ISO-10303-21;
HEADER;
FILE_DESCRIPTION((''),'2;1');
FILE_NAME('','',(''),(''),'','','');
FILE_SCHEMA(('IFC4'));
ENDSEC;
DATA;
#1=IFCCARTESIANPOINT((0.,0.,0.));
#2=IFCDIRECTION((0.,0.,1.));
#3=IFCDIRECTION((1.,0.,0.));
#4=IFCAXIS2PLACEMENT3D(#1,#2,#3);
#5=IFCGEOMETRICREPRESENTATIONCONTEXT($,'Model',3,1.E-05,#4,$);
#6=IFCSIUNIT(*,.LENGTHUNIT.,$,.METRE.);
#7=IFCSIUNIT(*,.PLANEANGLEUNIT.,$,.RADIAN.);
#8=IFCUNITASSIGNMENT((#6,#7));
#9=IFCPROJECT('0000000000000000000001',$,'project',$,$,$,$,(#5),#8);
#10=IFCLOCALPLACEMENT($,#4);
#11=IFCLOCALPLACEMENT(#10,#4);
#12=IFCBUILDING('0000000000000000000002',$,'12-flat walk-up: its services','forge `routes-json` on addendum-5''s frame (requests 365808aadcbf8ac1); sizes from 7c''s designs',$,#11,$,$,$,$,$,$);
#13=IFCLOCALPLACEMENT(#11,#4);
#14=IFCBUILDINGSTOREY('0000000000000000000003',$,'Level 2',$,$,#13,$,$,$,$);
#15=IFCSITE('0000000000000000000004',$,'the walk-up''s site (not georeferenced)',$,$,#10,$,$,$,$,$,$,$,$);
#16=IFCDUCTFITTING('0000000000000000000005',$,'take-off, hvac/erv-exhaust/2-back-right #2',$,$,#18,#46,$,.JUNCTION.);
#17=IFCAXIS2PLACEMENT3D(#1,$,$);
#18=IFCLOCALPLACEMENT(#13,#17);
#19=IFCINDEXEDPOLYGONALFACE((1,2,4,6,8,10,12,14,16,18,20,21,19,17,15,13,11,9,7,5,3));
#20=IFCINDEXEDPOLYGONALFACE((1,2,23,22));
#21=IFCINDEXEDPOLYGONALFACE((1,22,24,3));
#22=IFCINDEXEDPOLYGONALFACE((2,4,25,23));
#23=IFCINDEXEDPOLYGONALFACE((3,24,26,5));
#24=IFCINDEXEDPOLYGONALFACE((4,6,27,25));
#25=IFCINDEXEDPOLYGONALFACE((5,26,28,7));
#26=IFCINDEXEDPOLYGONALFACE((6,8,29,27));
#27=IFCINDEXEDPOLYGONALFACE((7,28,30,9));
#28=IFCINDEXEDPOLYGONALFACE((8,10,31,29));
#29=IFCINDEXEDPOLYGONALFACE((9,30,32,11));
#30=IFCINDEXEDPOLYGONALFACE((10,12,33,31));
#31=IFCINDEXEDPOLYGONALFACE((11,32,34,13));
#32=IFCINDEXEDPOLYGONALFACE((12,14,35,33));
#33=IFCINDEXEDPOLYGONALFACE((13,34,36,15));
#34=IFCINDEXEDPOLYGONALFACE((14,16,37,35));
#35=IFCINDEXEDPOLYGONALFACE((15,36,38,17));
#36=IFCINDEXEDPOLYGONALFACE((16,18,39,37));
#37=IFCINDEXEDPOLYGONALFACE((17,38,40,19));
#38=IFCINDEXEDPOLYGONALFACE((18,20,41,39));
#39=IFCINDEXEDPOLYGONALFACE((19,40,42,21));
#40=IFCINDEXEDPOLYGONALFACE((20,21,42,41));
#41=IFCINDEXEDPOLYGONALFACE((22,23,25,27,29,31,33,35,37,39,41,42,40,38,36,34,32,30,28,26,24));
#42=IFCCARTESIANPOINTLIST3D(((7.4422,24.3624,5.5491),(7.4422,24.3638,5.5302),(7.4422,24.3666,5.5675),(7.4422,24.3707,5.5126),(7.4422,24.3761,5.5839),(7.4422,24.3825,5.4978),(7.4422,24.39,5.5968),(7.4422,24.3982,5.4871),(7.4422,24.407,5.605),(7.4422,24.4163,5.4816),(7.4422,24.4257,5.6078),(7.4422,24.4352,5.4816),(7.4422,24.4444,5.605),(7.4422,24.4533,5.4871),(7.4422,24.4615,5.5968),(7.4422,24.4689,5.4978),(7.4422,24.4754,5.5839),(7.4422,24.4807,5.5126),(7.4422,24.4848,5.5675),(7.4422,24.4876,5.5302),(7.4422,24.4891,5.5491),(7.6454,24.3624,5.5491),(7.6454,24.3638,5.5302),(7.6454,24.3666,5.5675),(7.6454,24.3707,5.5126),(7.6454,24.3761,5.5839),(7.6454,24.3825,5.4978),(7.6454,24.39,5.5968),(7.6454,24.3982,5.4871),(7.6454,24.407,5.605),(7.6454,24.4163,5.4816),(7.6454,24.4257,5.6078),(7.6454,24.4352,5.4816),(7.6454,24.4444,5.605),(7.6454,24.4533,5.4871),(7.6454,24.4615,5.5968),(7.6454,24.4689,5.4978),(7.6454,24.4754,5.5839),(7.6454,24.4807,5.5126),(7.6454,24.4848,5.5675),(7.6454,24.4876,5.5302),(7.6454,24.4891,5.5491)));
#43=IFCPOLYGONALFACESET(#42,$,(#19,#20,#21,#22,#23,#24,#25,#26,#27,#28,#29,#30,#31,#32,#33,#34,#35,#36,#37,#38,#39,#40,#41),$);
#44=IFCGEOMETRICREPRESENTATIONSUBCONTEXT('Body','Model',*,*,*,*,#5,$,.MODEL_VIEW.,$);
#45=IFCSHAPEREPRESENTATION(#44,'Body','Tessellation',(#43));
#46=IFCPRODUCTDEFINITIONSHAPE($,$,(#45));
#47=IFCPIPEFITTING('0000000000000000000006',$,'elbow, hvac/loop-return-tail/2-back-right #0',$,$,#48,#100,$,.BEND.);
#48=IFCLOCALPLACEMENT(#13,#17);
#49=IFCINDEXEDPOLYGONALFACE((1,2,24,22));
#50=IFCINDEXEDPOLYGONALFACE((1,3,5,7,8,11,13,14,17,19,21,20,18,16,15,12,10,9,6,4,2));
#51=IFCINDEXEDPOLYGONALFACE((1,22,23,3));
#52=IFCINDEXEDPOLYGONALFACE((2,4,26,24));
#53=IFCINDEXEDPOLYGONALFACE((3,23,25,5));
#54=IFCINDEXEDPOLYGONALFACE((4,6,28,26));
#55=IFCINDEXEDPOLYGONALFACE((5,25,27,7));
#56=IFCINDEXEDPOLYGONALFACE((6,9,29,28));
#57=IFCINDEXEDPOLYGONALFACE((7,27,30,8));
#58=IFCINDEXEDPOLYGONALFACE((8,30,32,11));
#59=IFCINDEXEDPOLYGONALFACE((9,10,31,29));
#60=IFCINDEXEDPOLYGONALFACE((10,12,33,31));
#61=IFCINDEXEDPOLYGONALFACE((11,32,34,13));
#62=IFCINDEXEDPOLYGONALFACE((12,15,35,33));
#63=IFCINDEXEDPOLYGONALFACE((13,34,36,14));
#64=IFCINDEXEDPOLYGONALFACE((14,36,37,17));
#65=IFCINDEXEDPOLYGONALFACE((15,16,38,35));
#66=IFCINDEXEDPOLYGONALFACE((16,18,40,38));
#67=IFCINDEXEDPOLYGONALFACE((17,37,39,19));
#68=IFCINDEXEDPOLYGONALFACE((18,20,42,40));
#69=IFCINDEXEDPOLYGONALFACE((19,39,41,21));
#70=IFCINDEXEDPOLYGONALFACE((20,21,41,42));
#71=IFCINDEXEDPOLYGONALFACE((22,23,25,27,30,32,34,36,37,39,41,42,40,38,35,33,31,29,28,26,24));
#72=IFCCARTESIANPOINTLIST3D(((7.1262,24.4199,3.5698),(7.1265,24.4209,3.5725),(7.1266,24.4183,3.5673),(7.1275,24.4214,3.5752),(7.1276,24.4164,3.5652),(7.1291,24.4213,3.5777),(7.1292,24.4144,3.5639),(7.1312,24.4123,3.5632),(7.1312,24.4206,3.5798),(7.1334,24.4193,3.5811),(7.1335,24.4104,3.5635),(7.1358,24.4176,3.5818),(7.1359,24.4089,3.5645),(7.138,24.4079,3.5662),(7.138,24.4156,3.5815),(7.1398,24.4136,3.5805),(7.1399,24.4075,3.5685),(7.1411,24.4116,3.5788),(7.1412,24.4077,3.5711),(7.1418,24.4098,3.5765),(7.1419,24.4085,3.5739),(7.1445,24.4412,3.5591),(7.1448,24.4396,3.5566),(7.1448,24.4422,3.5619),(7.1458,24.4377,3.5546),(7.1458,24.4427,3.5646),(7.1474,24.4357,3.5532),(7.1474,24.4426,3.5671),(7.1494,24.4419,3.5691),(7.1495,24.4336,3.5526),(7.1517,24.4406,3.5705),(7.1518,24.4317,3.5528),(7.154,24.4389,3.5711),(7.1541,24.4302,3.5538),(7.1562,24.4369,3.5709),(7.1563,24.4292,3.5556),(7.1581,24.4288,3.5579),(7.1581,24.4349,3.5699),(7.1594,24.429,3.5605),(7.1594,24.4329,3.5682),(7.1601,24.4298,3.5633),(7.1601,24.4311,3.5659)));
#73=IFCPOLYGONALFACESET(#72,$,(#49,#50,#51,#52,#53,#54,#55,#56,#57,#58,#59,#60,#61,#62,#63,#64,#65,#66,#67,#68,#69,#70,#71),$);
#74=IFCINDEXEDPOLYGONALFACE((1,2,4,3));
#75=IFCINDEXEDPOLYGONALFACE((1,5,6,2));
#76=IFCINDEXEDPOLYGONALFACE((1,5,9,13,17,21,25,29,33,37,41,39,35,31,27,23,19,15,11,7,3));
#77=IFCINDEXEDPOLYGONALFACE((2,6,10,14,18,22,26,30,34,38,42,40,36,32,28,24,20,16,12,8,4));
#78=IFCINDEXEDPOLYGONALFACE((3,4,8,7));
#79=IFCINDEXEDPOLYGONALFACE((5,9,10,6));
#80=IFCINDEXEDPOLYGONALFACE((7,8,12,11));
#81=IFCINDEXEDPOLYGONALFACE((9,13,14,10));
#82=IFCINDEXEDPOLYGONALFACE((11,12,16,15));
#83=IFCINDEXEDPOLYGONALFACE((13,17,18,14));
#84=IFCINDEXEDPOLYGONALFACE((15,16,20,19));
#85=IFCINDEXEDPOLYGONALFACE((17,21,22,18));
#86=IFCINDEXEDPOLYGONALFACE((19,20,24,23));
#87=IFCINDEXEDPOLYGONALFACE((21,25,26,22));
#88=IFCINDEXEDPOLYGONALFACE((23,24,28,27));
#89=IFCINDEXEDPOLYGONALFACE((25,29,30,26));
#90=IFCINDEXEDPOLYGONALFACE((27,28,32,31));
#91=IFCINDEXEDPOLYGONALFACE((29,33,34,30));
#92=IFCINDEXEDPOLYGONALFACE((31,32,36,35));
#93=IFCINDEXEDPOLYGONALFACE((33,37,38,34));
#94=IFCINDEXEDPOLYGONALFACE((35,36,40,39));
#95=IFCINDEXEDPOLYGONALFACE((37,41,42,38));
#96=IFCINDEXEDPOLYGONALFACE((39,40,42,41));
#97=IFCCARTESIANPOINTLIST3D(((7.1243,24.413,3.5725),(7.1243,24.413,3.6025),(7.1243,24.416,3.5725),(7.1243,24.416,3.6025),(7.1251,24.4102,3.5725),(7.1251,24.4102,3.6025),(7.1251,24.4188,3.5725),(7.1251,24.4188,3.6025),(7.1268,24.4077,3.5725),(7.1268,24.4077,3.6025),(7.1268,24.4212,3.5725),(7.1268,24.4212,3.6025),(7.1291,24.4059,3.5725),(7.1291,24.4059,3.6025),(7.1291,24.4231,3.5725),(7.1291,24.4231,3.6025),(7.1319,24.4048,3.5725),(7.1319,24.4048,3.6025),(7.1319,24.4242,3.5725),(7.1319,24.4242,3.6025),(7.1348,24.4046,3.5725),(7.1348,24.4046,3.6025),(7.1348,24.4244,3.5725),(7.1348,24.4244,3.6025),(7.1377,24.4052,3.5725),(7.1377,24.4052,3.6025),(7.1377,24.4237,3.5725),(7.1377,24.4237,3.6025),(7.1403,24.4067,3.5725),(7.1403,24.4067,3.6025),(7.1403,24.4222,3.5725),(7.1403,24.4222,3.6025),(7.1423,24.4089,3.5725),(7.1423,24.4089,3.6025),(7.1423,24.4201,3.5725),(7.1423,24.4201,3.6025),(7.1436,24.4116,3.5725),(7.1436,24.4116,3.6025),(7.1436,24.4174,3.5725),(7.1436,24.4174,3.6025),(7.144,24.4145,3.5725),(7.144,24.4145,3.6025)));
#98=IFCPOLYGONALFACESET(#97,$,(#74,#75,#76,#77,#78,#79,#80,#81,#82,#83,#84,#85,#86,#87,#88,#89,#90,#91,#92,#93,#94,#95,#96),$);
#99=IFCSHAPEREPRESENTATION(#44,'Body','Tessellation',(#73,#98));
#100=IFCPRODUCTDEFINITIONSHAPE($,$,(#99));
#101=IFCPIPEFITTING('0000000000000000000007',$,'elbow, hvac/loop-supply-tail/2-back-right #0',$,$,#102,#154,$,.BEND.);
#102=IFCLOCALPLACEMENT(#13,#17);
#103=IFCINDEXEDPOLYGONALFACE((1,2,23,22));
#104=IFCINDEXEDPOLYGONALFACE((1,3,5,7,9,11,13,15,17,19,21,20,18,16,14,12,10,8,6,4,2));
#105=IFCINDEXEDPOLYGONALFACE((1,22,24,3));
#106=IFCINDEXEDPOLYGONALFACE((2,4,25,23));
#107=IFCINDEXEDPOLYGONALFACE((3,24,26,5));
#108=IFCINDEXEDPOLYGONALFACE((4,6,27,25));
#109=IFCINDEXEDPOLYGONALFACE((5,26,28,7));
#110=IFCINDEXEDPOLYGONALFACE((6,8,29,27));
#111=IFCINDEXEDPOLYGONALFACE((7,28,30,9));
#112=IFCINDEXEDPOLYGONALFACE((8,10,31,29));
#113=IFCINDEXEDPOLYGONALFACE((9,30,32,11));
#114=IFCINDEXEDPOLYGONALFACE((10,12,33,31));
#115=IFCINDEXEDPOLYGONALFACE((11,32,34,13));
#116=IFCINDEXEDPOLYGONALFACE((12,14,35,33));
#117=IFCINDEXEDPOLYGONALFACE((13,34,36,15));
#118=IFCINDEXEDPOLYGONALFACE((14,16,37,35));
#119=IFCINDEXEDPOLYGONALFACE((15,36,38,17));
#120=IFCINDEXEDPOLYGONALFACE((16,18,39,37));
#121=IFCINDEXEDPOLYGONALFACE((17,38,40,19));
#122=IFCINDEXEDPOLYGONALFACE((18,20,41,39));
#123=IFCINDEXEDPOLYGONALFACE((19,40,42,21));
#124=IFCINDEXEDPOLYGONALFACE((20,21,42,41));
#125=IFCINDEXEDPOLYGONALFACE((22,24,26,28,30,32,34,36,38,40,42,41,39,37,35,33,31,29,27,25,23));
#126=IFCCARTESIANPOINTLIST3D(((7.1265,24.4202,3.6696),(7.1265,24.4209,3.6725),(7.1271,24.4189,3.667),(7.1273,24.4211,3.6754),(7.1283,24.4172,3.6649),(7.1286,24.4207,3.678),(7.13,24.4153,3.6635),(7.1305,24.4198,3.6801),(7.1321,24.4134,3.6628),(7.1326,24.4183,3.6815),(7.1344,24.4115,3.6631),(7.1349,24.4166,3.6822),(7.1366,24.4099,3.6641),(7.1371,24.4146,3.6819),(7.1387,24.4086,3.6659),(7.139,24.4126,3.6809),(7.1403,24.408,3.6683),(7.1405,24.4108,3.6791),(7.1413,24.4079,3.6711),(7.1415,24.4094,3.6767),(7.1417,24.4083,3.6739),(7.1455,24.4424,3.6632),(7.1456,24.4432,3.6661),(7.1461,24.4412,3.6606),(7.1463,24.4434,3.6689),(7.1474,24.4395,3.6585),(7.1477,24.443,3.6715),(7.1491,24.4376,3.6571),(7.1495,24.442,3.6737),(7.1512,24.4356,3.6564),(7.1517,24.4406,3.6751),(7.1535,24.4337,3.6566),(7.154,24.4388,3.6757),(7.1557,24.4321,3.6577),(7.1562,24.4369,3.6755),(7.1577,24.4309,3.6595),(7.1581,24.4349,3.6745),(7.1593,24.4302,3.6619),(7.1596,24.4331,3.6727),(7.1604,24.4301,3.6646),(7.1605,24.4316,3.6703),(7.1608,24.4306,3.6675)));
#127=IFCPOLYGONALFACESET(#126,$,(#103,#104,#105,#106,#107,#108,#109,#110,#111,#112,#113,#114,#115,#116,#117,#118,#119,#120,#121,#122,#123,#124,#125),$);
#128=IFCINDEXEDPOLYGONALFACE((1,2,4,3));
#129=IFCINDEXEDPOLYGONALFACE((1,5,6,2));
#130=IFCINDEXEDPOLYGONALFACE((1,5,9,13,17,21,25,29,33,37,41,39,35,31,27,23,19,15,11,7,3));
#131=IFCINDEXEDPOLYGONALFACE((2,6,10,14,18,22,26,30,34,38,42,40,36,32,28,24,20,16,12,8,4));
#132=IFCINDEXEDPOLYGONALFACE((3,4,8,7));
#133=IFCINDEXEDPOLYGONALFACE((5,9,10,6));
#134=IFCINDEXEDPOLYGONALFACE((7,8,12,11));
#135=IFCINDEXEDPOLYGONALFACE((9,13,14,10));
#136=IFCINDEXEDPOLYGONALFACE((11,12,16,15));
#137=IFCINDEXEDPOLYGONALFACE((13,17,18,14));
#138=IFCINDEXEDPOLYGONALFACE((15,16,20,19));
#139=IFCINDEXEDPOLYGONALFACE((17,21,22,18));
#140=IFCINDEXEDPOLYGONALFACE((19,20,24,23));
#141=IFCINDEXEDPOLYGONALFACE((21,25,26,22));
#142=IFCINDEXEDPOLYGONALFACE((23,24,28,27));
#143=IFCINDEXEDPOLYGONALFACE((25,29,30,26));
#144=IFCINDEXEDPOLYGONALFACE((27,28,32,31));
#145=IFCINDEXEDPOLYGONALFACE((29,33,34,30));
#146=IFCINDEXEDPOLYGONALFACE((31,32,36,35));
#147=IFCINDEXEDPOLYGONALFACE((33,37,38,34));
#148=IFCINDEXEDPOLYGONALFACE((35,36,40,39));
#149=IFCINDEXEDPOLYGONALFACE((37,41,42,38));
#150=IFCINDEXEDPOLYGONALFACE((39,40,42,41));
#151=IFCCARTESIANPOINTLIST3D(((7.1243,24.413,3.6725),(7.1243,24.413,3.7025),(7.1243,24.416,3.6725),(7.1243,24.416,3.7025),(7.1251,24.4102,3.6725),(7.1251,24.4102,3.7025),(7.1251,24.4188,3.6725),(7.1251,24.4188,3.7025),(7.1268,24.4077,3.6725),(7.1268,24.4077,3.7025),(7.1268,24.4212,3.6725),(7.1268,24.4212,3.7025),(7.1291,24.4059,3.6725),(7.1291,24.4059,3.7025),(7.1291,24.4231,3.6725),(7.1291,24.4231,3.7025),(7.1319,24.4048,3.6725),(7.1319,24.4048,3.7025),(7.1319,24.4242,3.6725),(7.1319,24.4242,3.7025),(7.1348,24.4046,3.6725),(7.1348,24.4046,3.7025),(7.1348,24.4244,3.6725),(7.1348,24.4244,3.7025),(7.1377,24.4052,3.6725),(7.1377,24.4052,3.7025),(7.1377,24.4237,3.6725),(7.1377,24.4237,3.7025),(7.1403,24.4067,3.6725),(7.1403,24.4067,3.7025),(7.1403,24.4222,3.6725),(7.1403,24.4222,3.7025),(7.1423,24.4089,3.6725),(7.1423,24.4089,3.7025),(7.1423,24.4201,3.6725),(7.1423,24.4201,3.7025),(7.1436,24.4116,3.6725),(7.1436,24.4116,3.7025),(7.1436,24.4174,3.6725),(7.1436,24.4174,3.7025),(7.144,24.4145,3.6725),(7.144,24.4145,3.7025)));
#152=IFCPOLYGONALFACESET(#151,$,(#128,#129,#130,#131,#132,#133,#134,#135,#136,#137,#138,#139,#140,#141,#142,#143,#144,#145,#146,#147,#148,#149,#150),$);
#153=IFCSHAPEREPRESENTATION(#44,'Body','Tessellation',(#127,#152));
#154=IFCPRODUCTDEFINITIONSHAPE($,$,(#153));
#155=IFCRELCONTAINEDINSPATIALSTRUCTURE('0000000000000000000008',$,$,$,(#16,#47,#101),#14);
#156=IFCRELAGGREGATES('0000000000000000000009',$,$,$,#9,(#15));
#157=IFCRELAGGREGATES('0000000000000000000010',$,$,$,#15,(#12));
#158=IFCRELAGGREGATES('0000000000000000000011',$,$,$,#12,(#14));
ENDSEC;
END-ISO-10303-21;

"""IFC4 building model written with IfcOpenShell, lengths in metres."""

from ifc_helpers import new_model, entity, si_unit, frame, origin_with_axes, place, context, subcontext, project, spatial, element, save


model = new_model("IFC4")

# Units and contexts
model_context = context("Model", 3, precision=1e-05, world=origin_with_axes())
body_context = subcontext(model_context, "Body", "Model", "MODEL_VIEW")
ifc_project = project(units=[si_unit("LENGTHUNIT", "METRE"), si_unit("PLANEANGLEUNIT", "RADIAN")], contexts=[model_context])

# Site, building, storey
site_placement = place(None, origin_with_axes())
site = spatial("IfcSite", under=ifc_project, at=site_placement, Name="the walk-up's site (not georeferenced)")
building_placement = place(site_placement, origin_with_axes())
building = spatial("IfcBuilding", under=site, at=building_placement, Name="12-flat walk-up: its services", Description="forge `routes-json` on addendum-5's frame (requests 365808aadcbf8ac1); sizes from 7c's designs")
storey_placement = place(building_placement, origin_with_axes())
storey = spatial("IfcBuildingStorey", under=building, at=storey_placement, Name="Level 2")

# Duct fitting
duct_fitting_1_placement = place(storey_placement, frame((7.4422, 24.4257, 5.5443), z_axis=(0.0, 0.0, 1.0), x_axis=(1.0, 0.0, 0.0)))
element("IfcDuctFitting", 1, at=duct_fitting_1_placement, inside=storey, Name="take-off, hvac/erv-exhaust/2-back-right #2", PredefinedType="JUNCTION", context=body_context, shape_type="AdvancedSweptSolid", body=[
    entity("IfcSweptDiskSolid", entity("IfcPolyline", [entity("IfcCartesianPoint", [0.0, 0.0, 0.0]), entity("IfcCartesianPoint", [0.2032, 0.0, 0.0])]), 0.0635),
])

# Pipe fittings
pipe_fitting_1_placement = place(storey_placement, frame((7.1523, 24.4358, 3.5619), z_axis=(0.0, 0.0, 1.0), x_axis=(1.0, 0.0, 0.0)))
element("IfcPipeFitting", 2, at=pipe_fitting_1_placement, inside=storey, Name="elbow, hvac/loop-return-tail/2-back-right #0", PredefinedType="BEND", context=body_context, shape_type="AdvancedSweptSolid", body=[
    entity("IfcSweptDiskSolid", entity("IfcPolyline", [entity("IfcCartesianPoint", [0.0, 0.0, 0.0]), entity("IfcCartesianPoint", [-0.0183, -0.0213, 0.0106])]), 0.0099),
    entity("IfcSweptDiskSolid", entity("IfcPolyline", [entity("IfcCartesianPoint", [-0.0183, -0.0213, 0.0106]), entity("IfcCartesianPoint", [-0.0183, -0.0213, 0.0406])]), 0.0099),
])
pipe_fitting_2_placement = place(storey_placement, frame((7.1531, 24.4367, 3.6661), z_axis=(0.0, 0.0, 1.0), x_axis=(1.0, 0.0, 0.0)))
element("IfcPipeFitting", 3, at=pipe_fitting_2_placement, inside=storey, Name="elbow, hvac/loop-supply-tail/2-back-right #0", PredefinedType="BEND", context=body_context, shape_type="AdvancedSweptSolid", body=[
    entity("IfcSweptDiskSolid", entity("IfcPolyline", [entity("IfcCartesianPoint", [0.0, 0.0, 0.0]), entity("IfcCartesianPoint", [-0.0191, -0.0223, 0.0064])]), 0.0099),
    entity("IfcSweptDiskSolid", entity("IfcPolyline", [entity("IfcCartesianPoint", [-0.0191, -0.0223, 0.0064]), entity("IfcCartesianPoint", [-0.0191, -0.0223, 0.0364])]), 0.0099),
])

save(model, "model.ifc")
